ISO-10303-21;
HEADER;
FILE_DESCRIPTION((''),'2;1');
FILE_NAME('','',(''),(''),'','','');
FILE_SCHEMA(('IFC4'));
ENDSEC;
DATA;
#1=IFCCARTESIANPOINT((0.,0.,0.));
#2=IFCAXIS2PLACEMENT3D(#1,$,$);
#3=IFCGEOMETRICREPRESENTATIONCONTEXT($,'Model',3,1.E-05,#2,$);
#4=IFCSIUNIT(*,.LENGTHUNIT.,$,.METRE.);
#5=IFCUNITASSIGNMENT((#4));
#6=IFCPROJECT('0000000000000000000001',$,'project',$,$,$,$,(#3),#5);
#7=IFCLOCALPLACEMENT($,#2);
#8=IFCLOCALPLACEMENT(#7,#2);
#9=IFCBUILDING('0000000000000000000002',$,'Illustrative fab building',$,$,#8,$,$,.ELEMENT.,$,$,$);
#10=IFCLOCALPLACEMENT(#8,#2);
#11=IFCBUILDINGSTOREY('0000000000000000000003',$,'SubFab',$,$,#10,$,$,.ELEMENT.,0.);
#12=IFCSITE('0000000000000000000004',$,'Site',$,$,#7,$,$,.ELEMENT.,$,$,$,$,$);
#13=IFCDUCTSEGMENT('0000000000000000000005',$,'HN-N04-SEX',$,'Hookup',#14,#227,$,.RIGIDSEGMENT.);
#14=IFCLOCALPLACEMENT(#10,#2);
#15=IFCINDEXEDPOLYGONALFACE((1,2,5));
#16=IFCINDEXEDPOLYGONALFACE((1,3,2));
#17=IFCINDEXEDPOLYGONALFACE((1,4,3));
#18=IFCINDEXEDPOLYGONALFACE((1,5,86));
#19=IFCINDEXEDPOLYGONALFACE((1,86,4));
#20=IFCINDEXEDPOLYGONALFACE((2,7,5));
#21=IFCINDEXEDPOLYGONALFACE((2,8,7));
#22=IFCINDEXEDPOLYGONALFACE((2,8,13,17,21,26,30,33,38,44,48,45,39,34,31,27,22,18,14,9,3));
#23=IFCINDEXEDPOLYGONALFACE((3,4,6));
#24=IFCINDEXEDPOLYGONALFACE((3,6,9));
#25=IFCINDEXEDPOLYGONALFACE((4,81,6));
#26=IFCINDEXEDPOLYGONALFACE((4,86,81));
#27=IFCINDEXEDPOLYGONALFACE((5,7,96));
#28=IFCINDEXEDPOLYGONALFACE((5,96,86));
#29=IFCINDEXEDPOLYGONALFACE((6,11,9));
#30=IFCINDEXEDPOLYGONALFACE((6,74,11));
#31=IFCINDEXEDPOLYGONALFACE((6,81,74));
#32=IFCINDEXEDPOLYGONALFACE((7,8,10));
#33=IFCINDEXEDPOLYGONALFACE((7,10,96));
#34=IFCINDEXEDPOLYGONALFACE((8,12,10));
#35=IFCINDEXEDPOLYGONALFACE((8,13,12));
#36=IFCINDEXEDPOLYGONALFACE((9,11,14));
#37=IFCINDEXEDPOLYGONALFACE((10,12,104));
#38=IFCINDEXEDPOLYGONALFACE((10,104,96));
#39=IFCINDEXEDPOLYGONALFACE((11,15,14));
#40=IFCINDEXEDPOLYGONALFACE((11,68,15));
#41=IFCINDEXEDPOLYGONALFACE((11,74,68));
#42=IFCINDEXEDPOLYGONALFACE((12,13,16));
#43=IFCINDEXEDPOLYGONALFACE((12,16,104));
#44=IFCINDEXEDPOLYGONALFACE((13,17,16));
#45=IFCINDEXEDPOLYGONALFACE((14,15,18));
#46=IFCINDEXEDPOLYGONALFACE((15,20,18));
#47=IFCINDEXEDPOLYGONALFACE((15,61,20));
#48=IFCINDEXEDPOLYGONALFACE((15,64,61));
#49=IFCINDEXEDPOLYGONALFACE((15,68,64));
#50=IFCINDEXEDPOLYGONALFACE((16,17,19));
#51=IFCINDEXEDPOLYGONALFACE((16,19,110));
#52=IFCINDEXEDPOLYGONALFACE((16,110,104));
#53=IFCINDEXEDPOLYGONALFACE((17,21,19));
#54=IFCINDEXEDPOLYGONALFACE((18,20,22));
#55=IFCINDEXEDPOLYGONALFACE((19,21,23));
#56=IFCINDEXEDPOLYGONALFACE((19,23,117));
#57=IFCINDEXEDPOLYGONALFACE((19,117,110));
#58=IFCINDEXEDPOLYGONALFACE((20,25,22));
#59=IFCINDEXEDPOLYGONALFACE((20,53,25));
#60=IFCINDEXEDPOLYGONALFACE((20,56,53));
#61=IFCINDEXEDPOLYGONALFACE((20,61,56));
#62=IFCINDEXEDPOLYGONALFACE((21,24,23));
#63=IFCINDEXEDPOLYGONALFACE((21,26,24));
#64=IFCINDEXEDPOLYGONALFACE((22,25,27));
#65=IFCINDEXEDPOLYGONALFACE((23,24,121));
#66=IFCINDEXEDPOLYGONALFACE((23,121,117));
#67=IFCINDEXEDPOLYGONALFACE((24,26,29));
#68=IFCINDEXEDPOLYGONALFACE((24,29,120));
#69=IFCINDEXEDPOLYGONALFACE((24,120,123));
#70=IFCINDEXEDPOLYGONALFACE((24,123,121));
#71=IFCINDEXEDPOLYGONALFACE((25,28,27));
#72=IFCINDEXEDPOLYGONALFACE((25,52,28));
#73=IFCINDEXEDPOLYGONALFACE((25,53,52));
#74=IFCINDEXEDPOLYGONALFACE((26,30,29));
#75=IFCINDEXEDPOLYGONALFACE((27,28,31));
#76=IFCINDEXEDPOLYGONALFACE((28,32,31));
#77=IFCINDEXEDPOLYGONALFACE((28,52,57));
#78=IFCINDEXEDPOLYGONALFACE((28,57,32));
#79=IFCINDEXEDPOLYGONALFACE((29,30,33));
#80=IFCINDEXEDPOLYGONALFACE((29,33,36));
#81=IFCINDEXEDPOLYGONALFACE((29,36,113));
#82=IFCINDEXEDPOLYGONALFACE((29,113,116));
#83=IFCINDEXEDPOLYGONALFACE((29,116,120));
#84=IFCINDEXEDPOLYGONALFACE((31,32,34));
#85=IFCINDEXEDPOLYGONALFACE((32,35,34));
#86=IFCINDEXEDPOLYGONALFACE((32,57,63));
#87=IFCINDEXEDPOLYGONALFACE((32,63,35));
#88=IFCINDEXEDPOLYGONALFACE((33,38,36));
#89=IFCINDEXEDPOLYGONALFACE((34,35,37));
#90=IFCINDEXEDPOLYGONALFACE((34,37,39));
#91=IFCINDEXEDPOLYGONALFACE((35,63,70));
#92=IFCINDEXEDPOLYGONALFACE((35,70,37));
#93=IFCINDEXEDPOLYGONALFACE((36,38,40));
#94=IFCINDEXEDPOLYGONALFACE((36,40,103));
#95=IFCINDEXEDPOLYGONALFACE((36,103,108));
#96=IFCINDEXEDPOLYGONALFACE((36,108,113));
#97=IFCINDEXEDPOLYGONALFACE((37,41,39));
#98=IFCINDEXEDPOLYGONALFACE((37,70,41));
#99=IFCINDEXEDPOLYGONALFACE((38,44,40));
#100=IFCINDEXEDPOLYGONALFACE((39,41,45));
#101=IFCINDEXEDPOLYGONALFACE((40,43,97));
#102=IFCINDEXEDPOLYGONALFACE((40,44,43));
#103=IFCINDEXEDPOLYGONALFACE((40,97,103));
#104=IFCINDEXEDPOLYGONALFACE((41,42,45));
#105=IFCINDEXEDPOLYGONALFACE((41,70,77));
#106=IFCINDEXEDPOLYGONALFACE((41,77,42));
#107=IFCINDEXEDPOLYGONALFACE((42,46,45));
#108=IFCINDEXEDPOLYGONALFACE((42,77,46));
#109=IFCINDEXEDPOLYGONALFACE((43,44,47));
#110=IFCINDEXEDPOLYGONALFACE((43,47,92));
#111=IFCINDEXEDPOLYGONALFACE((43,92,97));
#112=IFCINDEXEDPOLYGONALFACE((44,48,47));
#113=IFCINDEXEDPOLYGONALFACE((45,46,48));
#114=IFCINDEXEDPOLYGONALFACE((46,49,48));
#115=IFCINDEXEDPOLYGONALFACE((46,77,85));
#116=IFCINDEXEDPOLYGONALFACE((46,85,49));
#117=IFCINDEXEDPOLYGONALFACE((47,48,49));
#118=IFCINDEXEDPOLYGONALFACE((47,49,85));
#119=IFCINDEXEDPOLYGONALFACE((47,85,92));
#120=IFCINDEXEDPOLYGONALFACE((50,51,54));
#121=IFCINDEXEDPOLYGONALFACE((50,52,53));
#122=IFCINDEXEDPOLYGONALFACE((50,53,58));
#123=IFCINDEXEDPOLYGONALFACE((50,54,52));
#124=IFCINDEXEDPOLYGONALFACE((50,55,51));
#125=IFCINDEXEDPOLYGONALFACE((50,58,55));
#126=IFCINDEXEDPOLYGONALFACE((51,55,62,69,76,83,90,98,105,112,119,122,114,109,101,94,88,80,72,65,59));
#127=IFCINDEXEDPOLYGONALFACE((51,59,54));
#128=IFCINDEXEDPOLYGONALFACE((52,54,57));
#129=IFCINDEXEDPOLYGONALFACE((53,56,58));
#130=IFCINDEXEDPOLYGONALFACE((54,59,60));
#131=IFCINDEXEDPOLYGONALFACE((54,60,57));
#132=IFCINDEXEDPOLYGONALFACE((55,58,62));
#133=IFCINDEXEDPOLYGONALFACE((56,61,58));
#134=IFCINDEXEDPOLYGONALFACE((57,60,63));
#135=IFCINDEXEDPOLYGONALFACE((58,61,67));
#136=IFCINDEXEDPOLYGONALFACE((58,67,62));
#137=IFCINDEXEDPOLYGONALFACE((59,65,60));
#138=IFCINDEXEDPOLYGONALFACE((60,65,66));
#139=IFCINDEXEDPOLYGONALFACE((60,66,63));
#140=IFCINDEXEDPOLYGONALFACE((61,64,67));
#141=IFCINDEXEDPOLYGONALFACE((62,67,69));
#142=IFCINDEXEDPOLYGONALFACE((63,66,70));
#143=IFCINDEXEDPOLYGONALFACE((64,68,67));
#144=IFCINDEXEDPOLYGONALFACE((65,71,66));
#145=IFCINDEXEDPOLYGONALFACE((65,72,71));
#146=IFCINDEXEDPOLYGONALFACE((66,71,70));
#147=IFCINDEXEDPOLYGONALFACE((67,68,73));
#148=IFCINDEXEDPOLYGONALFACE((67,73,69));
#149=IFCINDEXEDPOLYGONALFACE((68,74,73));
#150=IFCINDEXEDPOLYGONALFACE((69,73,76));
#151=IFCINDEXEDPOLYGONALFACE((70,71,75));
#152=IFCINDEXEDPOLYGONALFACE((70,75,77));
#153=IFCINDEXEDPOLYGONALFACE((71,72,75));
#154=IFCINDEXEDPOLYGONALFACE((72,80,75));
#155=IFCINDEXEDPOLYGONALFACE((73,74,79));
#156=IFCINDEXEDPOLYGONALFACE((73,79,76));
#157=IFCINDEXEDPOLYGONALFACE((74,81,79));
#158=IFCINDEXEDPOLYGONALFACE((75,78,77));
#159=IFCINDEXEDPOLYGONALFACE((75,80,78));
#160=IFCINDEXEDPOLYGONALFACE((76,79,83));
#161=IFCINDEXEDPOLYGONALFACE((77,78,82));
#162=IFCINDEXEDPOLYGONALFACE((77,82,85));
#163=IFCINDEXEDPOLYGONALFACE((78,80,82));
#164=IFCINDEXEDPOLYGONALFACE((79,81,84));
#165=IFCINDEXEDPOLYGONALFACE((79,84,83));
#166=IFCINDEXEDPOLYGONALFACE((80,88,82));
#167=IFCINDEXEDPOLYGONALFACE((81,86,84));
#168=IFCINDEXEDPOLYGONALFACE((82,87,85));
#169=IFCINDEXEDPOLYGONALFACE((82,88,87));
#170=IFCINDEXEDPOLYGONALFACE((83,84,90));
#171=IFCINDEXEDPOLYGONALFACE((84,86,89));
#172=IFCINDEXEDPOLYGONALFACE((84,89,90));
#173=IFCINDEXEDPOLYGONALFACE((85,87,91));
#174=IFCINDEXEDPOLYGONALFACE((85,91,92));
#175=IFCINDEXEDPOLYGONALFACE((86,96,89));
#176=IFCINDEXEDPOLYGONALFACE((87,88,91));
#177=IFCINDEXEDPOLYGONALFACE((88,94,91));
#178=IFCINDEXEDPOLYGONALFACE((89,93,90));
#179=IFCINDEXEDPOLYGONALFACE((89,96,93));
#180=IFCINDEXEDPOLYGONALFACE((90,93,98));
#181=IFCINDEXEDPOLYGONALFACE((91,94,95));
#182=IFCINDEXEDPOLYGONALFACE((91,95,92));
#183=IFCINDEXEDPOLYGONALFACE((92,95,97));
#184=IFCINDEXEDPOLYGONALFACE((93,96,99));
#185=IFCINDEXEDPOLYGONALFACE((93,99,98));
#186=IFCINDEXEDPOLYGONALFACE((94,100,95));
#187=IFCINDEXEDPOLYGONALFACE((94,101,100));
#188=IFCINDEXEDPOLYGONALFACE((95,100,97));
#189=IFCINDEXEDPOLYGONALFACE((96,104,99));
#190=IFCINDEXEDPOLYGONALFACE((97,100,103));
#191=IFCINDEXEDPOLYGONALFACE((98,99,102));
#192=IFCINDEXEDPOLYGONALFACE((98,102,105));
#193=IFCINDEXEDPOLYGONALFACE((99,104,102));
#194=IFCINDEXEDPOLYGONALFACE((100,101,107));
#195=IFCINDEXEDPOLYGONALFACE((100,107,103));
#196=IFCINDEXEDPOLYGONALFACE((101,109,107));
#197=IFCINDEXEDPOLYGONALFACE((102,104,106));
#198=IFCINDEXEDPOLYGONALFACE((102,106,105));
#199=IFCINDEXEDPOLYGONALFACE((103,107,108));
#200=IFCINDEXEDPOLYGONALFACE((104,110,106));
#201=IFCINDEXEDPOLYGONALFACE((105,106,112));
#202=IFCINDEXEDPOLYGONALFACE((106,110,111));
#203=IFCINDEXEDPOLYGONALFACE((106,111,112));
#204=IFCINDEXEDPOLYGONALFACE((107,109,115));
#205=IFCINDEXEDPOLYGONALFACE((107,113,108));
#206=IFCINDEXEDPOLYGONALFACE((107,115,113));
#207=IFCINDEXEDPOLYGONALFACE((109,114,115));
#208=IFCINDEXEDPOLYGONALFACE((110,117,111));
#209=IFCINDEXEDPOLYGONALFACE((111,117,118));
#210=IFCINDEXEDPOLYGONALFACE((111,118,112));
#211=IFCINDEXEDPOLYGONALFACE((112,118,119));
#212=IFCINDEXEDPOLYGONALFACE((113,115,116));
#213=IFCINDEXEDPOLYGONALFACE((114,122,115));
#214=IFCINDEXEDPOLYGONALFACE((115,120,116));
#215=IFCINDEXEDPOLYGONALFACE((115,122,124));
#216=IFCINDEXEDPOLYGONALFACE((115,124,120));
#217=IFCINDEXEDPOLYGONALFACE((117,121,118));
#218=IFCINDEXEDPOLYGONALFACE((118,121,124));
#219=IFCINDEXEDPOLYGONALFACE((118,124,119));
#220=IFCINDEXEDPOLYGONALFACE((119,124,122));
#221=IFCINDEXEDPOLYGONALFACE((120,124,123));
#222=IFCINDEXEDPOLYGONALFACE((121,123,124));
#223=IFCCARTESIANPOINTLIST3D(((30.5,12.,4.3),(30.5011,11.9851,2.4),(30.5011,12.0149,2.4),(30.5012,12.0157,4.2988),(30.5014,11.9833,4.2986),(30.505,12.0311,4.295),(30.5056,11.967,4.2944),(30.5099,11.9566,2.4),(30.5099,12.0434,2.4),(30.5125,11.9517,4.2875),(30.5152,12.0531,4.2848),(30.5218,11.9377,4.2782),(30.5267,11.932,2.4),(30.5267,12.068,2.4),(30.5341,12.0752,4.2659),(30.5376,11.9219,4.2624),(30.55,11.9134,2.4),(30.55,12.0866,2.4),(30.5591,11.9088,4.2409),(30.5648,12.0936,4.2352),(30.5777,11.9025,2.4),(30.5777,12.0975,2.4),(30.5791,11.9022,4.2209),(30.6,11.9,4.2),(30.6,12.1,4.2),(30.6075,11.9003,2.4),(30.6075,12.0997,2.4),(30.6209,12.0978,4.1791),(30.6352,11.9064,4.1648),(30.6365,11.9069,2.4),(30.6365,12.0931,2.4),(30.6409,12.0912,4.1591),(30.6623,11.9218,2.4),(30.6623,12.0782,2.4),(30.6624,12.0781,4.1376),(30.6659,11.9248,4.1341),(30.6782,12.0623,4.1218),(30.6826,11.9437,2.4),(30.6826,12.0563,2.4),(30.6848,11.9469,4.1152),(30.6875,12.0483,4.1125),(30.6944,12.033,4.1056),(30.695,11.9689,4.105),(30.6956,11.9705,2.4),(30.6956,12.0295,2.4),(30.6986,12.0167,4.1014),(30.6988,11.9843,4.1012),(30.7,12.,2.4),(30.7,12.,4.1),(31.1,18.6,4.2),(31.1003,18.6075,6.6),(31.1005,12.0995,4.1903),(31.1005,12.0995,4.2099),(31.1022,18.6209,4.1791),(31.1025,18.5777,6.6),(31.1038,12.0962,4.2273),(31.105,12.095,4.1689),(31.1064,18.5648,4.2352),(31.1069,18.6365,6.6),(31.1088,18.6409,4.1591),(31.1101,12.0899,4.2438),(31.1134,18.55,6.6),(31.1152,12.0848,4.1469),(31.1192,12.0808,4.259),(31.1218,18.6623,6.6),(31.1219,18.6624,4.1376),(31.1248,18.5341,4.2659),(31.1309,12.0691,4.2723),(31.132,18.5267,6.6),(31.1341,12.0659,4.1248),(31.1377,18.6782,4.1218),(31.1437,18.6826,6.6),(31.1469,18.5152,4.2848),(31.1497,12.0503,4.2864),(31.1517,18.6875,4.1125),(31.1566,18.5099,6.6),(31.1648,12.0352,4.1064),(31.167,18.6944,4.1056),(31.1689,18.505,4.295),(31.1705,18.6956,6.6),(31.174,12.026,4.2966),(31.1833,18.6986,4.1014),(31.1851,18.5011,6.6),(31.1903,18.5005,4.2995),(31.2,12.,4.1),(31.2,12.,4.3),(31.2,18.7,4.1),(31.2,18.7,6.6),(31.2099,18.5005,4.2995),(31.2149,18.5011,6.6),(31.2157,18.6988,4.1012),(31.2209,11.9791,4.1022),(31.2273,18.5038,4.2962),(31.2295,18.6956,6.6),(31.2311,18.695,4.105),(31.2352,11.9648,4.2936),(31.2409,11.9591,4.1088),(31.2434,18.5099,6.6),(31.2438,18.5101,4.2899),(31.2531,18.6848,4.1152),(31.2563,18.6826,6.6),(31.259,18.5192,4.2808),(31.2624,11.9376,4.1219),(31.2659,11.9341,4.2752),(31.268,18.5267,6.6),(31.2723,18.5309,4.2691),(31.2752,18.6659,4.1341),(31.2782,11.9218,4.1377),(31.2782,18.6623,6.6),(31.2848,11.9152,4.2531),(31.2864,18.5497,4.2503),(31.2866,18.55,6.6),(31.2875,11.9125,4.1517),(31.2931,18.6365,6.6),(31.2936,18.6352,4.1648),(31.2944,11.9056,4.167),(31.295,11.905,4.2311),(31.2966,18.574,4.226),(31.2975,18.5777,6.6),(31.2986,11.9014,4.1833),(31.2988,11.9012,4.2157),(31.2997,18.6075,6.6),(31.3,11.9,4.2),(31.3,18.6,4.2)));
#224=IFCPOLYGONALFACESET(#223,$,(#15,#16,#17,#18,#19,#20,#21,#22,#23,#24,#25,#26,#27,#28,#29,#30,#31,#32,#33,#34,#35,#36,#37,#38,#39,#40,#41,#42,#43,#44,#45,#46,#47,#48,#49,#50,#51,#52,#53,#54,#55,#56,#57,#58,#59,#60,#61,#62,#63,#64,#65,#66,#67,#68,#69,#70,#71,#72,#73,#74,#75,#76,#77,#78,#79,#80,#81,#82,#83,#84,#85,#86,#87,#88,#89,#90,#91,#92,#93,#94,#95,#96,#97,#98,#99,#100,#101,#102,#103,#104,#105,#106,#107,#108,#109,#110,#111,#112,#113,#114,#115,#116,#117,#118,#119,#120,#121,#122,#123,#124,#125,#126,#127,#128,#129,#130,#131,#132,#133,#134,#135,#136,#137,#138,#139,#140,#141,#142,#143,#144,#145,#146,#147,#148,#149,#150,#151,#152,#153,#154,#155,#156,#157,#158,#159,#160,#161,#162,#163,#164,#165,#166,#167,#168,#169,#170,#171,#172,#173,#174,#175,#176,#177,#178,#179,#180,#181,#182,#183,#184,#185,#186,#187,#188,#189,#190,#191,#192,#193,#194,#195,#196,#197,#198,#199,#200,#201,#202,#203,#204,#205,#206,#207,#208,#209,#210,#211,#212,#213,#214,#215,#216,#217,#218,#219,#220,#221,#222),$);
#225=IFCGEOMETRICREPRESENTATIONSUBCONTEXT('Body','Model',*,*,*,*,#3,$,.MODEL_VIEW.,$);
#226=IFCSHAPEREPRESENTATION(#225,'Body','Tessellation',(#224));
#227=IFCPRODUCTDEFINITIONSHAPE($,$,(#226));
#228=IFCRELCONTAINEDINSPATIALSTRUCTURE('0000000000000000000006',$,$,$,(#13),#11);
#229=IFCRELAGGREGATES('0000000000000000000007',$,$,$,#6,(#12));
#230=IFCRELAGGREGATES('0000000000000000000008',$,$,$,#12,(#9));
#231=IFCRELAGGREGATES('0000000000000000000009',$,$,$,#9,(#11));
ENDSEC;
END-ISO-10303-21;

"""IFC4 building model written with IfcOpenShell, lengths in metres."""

from ifc_helpers import new_model, entity, si_unit, origin, place, context, subcontext, project, spatial, element, save


model = new_model("IFC4")

# Units and contexts
model_context = context("Model", 3, precision=1e-05, world=origin())
body_context = subcontext(model_context, "Body", "Model", "MODEL_VIEW")
ifc_project = project(units=[si_unit("LENGTHUNIT", "METRE")], contexts=[model_context])

# Site, building, storey
site_placement = place(None, origin())
site = spatial("IfcSite", under=ifc_project, at=site_placement, Name="Site", CompositionType="ELEMENT")
building_placement = place(site_placement, origin())
building = spatial("IfcBuilding", under=site, at=building_placement, Name="Illustrative fab building", CompositionType="ELEMENT")
storey_placement = place(building_placement, origin())
storey = spatial("IfcBuildingStorey", under=building, at=storey_placement, Name="SubFab", CompositionType="ELEMENT", Elevation=0.0)

# Duct segment
duct_segment_1_placement = place(storey_placement, origin())
element("IfcDuctSegment", 1, at=duct_segment_1_placement, inside=storey, Name="HN-N04-SEX", ObjectType="Hookup", PredefinedType="RIGIDSEGMENT", context=body_context, shape_type="AdvancedSweptSolid", body=[
    entity("IfcSweptDiskSolid", entity("IfcPolyline", [entity("IfcCartesianPoint", [30.6, 12.0, 2.4]), entity("IfcCartesianPoint", [30.6, 12.0, 4.2]), entity("IfcCartesianPoint", [31.2, 12.0, 4.2]), entity("IfcCartesianPoint", [31.2, 18.6, 4.2]), entity("IfcCartesianPoint", [31.2, 18.6, 6.6])]), 0.1),
])

save(model, "model.ifc")
